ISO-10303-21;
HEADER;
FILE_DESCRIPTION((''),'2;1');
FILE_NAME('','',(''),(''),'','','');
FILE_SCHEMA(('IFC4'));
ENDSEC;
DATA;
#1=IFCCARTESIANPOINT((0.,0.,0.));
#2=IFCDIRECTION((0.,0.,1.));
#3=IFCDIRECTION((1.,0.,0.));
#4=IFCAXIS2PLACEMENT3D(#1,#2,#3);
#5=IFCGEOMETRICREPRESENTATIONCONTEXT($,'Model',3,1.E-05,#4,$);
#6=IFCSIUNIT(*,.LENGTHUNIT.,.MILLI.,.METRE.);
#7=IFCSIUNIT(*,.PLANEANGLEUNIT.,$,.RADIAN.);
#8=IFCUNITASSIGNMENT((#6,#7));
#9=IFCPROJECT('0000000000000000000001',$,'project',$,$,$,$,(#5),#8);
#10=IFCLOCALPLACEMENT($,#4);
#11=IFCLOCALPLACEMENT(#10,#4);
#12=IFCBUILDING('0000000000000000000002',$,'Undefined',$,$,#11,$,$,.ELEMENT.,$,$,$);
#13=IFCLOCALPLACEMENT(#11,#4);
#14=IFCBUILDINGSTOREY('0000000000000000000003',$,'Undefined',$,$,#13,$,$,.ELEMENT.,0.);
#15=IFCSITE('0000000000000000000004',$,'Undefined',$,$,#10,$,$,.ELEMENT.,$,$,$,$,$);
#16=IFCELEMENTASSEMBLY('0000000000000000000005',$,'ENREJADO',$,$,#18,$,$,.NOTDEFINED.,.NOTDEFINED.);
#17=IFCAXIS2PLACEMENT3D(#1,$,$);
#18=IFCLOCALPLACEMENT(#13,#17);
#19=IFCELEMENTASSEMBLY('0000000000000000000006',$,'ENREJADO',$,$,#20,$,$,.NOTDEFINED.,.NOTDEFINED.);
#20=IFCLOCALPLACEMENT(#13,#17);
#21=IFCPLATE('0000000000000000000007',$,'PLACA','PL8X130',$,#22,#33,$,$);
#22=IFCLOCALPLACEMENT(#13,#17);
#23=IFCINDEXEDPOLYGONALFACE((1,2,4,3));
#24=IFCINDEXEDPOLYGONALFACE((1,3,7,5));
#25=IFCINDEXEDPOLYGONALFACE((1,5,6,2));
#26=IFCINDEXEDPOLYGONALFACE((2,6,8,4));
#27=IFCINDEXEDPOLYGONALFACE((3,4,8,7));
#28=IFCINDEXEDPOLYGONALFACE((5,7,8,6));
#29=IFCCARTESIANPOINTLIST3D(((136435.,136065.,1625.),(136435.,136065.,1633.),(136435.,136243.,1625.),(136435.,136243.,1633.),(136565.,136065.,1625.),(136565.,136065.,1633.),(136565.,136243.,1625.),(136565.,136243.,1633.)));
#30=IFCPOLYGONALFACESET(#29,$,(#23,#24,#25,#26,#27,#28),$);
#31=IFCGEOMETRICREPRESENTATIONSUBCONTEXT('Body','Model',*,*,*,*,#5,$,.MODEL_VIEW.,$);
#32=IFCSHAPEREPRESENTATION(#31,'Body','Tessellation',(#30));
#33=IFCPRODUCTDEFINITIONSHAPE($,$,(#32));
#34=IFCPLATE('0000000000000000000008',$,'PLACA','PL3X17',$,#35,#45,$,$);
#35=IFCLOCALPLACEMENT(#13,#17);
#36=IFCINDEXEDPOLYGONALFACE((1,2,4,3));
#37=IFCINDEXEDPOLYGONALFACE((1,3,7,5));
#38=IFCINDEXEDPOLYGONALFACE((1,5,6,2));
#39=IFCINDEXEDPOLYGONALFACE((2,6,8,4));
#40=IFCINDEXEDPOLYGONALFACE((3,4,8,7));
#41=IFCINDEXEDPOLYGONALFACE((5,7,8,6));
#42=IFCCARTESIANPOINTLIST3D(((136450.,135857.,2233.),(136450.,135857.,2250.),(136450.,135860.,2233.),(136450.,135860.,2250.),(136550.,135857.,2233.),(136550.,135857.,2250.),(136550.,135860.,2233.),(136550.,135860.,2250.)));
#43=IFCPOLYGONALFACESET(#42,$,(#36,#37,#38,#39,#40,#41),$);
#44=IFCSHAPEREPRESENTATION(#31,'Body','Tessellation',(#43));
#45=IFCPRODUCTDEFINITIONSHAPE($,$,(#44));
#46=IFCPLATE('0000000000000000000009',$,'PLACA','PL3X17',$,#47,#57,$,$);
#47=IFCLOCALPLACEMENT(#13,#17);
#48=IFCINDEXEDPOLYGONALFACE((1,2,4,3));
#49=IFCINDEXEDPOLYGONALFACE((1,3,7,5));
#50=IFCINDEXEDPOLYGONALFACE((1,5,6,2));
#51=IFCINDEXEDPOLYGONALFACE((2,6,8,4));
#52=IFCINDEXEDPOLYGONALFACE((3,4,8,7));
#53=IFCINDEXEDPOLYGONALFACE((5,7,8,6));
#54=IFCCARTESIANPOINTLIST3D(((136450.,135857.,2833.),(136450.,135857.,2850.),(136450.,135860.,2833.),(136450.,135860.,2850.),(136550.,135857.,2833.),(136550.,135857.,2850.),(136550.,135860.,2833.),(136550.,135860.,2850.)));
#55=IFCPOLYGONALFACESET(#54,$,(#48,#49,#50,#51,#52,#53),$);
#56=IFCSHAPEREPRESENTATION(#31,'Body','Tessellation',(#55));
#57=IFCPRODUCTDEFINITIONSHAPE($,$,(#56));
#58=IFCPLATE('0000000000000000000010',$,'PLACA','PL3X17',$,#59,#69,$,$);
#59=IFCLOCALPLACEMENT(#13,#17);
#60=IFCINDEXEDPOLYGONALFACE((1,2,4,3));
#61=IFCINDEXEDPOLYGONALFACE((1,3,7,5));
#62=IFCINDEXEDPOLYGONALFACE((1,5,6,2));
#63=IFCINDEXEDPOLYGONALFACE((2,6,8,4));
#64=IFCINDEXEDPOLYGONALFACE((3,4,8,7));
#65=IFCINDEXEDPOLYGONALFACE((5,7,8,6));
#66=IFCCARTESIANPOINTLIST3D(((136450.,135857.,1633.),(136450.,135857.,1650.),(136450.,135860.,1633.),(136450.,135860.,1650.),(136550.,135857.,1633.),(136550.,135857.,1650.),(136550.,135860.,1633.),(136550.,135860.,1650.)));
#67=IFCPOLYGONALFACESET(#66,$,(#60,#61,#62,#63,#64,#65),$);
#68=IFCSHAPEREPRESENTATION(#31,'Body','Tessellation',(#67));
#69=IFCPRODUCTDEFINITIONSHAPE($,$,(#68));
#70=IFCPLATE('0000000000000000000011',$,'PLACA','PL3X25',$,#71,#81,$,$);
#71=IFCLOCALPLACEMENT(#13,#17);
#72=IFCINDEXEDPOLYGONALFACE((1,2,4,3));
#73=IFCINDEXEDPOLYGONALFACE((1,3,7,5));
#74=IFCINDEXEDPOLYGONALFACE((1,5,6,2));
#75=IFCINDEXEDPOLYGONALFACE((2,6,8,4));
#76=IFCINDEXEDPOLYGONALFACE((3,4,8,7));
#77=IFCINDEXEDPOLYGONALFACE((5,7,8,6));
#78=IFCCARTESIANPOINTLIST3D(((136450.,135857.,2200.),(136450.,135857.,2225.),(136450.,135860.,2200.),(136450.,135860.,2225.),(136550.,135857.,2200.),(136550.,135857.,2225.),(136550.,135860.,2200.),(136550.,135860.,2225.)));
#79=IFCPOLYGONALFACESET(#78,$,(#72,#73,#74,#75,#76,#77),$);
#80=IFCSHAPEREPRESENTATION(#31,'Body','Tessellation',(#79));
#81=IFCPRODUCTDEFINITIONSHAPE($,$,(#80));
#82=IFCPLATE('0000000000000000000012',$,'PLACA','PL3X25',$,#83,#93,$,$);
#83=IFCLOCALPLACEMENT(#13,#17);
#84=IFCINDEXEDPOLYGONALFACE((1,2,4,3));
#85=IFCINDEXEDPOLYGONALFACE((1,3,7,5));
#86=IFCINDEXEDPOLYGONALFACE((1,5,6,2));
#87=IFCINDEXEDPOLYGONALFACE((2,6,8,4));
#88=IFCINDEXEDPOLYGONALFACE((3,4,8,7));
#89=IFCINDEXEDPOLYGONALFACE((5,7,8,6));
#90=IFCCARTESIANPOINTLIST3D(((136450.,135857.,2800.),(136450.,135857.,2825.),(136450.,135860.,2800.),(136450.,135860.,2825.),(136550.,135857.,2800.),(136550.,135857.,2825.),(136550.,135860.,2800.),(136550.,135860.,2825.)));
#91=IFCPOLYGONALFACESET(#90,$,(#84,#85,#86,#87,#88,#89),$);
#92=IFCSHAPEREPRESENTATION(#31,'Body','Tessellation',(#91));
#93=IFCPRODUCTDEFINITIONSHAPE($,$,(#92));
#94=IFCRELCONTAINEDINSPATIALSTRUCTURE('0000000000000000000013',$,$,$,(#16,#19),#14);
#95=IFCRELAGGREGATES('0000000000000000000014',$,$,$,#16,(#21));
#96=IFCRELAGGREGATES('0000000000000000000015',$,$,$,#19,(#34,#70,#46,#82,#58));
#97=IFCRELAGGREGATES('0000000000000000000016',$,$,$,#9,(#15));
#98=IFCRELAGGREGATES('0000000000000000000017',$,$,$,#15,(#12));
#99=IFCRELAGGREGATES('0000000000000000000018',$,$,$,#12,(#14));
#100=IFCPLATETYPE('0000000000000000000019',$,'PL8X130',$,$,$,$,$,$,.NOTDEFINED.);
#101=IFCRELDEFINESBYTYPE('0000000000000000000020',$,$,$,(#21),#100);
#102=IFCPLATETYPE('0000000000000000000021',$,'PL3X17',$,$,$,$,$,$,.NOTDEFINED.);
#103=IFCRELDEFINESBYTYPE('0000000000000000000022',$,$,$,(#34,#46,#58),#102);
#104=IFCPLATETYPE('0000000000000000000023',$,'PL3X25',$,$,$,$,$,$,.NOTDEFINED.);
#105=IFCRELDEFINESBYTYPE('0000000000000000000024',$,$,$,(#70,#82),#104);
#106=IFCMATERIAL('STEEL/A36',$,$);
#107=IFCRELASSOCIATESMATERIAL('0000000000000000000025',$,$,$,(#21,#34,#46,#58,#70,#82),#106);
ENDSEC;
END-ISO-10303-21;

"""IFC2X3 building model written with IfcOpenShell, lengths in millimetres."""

from ifc_helpers import new_model, si_unit, frame, origin_with_axes, place, context, subcontext, project, spatial, polyline, outline, extrude, material, type_object, element, aggregate, save


model = new_model("IFC2X3")

# Units and contexts
model_context = context("Model", 3, precision=1e-05, world=origin_with_axes())
body_context = subcontext(model_context, "Body", "Model", "MODEL_VIEW")
ifc_project = project(units=[si_unit("LENGTHUNIT", "METRE", prefix="MILLI"), si_unit("PLANEANGLEUNIT", "RADIAN")], contexts=[model_context])

# Site, building, storey
site_placement = place(None, origin_with_axes())
site = spatial("IfcSite", under=ifc_project, at=site_placement, Name="Undefined", CompositionType="ELEMENT")
building_placement = place(site_placement, origin_with_axes())
building = spatial("IfcBuilding", under=site, at=building_placement, Name="Undefined", CompositionType="ELEMENT")
storey_placement = place(building_placement, origin_with_axes())
storey = spatial("IfcBuildingStorey", under=building, at=storey_placement, Name="Undefined", CompositionType="ELEMENT", Elevation=0.0)

# Shared definitions
ifc_material_1 = material(Name="STEEL/A36")

# Element assembly
assembly_1_placement = place(storey_placement, origin_with_axes())
assembly_1 = element("IfcElementAssembly", 1, at=assembly_1_placement, inside=storey, Name="ENREJADO", AssemblyPlace="NOTDEFINED", PredefinedType="NOTDEFINED")

# Shared definitions
plate_type_1 = type_object("IfcPlateType", Name="PL8X130", PredefinedType="NOTDEFINED")

# Element assembly
assembly_2_placement = place(storey_placement, origin_with_axes())
assembly_2 = element("IfcElementAssembly", 2, at=assembly_2_placement, inside=storey, Name="ENREJADO", AssemblyPlace="NOTDEFINED", PredefinedType="NOTDEFINED")

# Plates
plate_1_placement = place(assembly_1_placement, frame((136500.0, 136065.0, 1629.0), z_axis=(0.0, 0.0, -1.0), x_axis=(0.0, 1.0, 0.0)))
plate_1 = element("IfcPlate", 3, at=plate_1_placement, type_object=plate_type_1, material=ifc_material_1, Name="PLACA", Description="PL8X130", context=body_context, shape_type="SweptSolid", body=[
    extrude(outline(polyline([(0.0, -65.0), (0.0, 65.0), (178.0, 65.0), (178.0, -65.0), (0.0, -65.0)])), frame((0.0, 0.0, -4.0), z_axis=(0.0, 0.0, 1.0), x_axis=(1.0, 0.0, 0.0)), (0.0, 0.0, 1.0), 8.0),
])
aggregate(assembly_1, [plate_1])
plate_type_2 = type_object("IfcPlateType", Name="PL3X17", PredefinedType="NOTDEFINED")
plate_2_placement = place(assembly_2_placement, frame((136450.0, 135858.5, 2250.0), z_axis=(0.0, -1.0, 0.0), x_axis=(0.0, 0.0, -1.0)))
plate_2 = element("IfcPlate", 4, at=plate_2_placement, type_object=plate_type_2, material=ifc_material_1, Name="PLACA", Description="PL3X17", context=body_context, shape_type="SweptSolid", body=[
    extrude(outline(polyline([(0.0, 0.0), (17.0, 0.0), (17.0, 100.0), (0.0, 100.0), (0.0, 0.0)])), frame((0.0, 0.0, -1.5), z_axis=(0.0, 0.0, 1.0), x_axis=(1.0, 0.0, 0.0)), (0.0, 0.0, 1.0), 3.0),
])
plate_3_placement = place(assembly_2_placement, frame((136450.0, 135858.5, 2850.0), z_axis=(0.0, -1.0, 0.0), x_axis=(0.0, 0.0, -1.0)))
plate_3 = element("IfcPlate", 5, at=plate_3_placement, type_object=plate_type_2, material=ifc_material_1, Name="PLACA", Description="PL3X17", context=body_context, shape_type="SweptSolid", body=[
    extrude(outline(polyline([(0.0, 0.0), (17.0, 0.0), (17.0, 100.0), (0.0, 100.0), (0.0, 0.0)])), frame((0.0, 0.0, -1.5), z_axis=(0.0, 0.0, 1.0), x_axis=(1.0, 0.0, 0.0)), (0.0, 0.0, 1.0), 3.0),
])
plate_4_placement = place(assembly_2_placement, frame((136450.0, 135858.5, 1650.0), z_axis=(0.0, -1.0, 0.0), x_axis=(0.0, 0.0, -1.0)))
plate_4 = element("IfcPlate", 6, at=plate_4_placement, type_object=plate_type_2, material=ifc_material_1, Name="PLACA", Description="PL3X17", context=body_context, shape_type="SweptSolid", body=[
    extrude(outline(polyline([(0.0, 0.0), (17.0, 0.0), (17.0, 100.0), (0.0, 100.0), (0.0, 0.0)])), frame((0.0, 0.0, -1.5), z_axis=(0.0, 0.0, 1.0), x_axis=(1.0, 0.0, 0.0)), (0.0, 0.0, 1.0), 3.0),
])
plate_type_3 = type_object("IfcPlateType", Name="PL3X25", PredefinedType="NOTDEFINED")
plate_5_placement = place(assembly_2_placement, frame((136450.0, 135858.5, 2225.0), z_axis=(0.0, -1.0, 0.0), x_axis=(0.0, 0.0, -1.0)))
plate_5 = element("IfcPlate", 7, at=plate_5_placement, type_object=plate_type_3, material=ifc_material_1, Name="PLACA", Description="PL3X25", context=body_context, shape_type="SweptSolid", body=[
    extrude(outline(polyline([(0.0, 0.0), (25.0, 0.0), (25.0, 100.0), (0.0, 100.0), (0.0, 0.0)])), frame((0.0, 0.0, -1.5), z_axis=(0.0, 0.0, 1.0), x_axis=(1.0, 0.0, 0.0)), (0.0, 0.0, 1.0), 3.0),
])
plate_6_placement = place(assembly_2_placement, frame((136450.0, 135858.5, 2825.0), z_axis=(0.0, -1.0, 0.0), x_axis=(0.0, 0.0, -1.0)))
plate_6 = element("IfcPlate", 8, at=plate_6_placement, type_object=plate_type_3, material=ifc_material_1, Name="PLACA", Description="PL3X25", context=body_context, shape_type="SweptSolid", body=[
    extrude(outline(polyline([(0.0, 0.0), (25.0, 0.0), (25.0, 100.0), (0.0, 100.0), (0.0, 0.0)])), frame((0.0, 0.0, -1.5), z_axis=(0.0, 0.0, 1.0), x_axis=(1.0, 0.0, 0.0)), (0.0, 0.0, 1.0), 3.0),
])
aggregate(assembly_2, [plate_2, plate_5, plate_3, plate_6, plate_4])

save(model, "model.ifc")
